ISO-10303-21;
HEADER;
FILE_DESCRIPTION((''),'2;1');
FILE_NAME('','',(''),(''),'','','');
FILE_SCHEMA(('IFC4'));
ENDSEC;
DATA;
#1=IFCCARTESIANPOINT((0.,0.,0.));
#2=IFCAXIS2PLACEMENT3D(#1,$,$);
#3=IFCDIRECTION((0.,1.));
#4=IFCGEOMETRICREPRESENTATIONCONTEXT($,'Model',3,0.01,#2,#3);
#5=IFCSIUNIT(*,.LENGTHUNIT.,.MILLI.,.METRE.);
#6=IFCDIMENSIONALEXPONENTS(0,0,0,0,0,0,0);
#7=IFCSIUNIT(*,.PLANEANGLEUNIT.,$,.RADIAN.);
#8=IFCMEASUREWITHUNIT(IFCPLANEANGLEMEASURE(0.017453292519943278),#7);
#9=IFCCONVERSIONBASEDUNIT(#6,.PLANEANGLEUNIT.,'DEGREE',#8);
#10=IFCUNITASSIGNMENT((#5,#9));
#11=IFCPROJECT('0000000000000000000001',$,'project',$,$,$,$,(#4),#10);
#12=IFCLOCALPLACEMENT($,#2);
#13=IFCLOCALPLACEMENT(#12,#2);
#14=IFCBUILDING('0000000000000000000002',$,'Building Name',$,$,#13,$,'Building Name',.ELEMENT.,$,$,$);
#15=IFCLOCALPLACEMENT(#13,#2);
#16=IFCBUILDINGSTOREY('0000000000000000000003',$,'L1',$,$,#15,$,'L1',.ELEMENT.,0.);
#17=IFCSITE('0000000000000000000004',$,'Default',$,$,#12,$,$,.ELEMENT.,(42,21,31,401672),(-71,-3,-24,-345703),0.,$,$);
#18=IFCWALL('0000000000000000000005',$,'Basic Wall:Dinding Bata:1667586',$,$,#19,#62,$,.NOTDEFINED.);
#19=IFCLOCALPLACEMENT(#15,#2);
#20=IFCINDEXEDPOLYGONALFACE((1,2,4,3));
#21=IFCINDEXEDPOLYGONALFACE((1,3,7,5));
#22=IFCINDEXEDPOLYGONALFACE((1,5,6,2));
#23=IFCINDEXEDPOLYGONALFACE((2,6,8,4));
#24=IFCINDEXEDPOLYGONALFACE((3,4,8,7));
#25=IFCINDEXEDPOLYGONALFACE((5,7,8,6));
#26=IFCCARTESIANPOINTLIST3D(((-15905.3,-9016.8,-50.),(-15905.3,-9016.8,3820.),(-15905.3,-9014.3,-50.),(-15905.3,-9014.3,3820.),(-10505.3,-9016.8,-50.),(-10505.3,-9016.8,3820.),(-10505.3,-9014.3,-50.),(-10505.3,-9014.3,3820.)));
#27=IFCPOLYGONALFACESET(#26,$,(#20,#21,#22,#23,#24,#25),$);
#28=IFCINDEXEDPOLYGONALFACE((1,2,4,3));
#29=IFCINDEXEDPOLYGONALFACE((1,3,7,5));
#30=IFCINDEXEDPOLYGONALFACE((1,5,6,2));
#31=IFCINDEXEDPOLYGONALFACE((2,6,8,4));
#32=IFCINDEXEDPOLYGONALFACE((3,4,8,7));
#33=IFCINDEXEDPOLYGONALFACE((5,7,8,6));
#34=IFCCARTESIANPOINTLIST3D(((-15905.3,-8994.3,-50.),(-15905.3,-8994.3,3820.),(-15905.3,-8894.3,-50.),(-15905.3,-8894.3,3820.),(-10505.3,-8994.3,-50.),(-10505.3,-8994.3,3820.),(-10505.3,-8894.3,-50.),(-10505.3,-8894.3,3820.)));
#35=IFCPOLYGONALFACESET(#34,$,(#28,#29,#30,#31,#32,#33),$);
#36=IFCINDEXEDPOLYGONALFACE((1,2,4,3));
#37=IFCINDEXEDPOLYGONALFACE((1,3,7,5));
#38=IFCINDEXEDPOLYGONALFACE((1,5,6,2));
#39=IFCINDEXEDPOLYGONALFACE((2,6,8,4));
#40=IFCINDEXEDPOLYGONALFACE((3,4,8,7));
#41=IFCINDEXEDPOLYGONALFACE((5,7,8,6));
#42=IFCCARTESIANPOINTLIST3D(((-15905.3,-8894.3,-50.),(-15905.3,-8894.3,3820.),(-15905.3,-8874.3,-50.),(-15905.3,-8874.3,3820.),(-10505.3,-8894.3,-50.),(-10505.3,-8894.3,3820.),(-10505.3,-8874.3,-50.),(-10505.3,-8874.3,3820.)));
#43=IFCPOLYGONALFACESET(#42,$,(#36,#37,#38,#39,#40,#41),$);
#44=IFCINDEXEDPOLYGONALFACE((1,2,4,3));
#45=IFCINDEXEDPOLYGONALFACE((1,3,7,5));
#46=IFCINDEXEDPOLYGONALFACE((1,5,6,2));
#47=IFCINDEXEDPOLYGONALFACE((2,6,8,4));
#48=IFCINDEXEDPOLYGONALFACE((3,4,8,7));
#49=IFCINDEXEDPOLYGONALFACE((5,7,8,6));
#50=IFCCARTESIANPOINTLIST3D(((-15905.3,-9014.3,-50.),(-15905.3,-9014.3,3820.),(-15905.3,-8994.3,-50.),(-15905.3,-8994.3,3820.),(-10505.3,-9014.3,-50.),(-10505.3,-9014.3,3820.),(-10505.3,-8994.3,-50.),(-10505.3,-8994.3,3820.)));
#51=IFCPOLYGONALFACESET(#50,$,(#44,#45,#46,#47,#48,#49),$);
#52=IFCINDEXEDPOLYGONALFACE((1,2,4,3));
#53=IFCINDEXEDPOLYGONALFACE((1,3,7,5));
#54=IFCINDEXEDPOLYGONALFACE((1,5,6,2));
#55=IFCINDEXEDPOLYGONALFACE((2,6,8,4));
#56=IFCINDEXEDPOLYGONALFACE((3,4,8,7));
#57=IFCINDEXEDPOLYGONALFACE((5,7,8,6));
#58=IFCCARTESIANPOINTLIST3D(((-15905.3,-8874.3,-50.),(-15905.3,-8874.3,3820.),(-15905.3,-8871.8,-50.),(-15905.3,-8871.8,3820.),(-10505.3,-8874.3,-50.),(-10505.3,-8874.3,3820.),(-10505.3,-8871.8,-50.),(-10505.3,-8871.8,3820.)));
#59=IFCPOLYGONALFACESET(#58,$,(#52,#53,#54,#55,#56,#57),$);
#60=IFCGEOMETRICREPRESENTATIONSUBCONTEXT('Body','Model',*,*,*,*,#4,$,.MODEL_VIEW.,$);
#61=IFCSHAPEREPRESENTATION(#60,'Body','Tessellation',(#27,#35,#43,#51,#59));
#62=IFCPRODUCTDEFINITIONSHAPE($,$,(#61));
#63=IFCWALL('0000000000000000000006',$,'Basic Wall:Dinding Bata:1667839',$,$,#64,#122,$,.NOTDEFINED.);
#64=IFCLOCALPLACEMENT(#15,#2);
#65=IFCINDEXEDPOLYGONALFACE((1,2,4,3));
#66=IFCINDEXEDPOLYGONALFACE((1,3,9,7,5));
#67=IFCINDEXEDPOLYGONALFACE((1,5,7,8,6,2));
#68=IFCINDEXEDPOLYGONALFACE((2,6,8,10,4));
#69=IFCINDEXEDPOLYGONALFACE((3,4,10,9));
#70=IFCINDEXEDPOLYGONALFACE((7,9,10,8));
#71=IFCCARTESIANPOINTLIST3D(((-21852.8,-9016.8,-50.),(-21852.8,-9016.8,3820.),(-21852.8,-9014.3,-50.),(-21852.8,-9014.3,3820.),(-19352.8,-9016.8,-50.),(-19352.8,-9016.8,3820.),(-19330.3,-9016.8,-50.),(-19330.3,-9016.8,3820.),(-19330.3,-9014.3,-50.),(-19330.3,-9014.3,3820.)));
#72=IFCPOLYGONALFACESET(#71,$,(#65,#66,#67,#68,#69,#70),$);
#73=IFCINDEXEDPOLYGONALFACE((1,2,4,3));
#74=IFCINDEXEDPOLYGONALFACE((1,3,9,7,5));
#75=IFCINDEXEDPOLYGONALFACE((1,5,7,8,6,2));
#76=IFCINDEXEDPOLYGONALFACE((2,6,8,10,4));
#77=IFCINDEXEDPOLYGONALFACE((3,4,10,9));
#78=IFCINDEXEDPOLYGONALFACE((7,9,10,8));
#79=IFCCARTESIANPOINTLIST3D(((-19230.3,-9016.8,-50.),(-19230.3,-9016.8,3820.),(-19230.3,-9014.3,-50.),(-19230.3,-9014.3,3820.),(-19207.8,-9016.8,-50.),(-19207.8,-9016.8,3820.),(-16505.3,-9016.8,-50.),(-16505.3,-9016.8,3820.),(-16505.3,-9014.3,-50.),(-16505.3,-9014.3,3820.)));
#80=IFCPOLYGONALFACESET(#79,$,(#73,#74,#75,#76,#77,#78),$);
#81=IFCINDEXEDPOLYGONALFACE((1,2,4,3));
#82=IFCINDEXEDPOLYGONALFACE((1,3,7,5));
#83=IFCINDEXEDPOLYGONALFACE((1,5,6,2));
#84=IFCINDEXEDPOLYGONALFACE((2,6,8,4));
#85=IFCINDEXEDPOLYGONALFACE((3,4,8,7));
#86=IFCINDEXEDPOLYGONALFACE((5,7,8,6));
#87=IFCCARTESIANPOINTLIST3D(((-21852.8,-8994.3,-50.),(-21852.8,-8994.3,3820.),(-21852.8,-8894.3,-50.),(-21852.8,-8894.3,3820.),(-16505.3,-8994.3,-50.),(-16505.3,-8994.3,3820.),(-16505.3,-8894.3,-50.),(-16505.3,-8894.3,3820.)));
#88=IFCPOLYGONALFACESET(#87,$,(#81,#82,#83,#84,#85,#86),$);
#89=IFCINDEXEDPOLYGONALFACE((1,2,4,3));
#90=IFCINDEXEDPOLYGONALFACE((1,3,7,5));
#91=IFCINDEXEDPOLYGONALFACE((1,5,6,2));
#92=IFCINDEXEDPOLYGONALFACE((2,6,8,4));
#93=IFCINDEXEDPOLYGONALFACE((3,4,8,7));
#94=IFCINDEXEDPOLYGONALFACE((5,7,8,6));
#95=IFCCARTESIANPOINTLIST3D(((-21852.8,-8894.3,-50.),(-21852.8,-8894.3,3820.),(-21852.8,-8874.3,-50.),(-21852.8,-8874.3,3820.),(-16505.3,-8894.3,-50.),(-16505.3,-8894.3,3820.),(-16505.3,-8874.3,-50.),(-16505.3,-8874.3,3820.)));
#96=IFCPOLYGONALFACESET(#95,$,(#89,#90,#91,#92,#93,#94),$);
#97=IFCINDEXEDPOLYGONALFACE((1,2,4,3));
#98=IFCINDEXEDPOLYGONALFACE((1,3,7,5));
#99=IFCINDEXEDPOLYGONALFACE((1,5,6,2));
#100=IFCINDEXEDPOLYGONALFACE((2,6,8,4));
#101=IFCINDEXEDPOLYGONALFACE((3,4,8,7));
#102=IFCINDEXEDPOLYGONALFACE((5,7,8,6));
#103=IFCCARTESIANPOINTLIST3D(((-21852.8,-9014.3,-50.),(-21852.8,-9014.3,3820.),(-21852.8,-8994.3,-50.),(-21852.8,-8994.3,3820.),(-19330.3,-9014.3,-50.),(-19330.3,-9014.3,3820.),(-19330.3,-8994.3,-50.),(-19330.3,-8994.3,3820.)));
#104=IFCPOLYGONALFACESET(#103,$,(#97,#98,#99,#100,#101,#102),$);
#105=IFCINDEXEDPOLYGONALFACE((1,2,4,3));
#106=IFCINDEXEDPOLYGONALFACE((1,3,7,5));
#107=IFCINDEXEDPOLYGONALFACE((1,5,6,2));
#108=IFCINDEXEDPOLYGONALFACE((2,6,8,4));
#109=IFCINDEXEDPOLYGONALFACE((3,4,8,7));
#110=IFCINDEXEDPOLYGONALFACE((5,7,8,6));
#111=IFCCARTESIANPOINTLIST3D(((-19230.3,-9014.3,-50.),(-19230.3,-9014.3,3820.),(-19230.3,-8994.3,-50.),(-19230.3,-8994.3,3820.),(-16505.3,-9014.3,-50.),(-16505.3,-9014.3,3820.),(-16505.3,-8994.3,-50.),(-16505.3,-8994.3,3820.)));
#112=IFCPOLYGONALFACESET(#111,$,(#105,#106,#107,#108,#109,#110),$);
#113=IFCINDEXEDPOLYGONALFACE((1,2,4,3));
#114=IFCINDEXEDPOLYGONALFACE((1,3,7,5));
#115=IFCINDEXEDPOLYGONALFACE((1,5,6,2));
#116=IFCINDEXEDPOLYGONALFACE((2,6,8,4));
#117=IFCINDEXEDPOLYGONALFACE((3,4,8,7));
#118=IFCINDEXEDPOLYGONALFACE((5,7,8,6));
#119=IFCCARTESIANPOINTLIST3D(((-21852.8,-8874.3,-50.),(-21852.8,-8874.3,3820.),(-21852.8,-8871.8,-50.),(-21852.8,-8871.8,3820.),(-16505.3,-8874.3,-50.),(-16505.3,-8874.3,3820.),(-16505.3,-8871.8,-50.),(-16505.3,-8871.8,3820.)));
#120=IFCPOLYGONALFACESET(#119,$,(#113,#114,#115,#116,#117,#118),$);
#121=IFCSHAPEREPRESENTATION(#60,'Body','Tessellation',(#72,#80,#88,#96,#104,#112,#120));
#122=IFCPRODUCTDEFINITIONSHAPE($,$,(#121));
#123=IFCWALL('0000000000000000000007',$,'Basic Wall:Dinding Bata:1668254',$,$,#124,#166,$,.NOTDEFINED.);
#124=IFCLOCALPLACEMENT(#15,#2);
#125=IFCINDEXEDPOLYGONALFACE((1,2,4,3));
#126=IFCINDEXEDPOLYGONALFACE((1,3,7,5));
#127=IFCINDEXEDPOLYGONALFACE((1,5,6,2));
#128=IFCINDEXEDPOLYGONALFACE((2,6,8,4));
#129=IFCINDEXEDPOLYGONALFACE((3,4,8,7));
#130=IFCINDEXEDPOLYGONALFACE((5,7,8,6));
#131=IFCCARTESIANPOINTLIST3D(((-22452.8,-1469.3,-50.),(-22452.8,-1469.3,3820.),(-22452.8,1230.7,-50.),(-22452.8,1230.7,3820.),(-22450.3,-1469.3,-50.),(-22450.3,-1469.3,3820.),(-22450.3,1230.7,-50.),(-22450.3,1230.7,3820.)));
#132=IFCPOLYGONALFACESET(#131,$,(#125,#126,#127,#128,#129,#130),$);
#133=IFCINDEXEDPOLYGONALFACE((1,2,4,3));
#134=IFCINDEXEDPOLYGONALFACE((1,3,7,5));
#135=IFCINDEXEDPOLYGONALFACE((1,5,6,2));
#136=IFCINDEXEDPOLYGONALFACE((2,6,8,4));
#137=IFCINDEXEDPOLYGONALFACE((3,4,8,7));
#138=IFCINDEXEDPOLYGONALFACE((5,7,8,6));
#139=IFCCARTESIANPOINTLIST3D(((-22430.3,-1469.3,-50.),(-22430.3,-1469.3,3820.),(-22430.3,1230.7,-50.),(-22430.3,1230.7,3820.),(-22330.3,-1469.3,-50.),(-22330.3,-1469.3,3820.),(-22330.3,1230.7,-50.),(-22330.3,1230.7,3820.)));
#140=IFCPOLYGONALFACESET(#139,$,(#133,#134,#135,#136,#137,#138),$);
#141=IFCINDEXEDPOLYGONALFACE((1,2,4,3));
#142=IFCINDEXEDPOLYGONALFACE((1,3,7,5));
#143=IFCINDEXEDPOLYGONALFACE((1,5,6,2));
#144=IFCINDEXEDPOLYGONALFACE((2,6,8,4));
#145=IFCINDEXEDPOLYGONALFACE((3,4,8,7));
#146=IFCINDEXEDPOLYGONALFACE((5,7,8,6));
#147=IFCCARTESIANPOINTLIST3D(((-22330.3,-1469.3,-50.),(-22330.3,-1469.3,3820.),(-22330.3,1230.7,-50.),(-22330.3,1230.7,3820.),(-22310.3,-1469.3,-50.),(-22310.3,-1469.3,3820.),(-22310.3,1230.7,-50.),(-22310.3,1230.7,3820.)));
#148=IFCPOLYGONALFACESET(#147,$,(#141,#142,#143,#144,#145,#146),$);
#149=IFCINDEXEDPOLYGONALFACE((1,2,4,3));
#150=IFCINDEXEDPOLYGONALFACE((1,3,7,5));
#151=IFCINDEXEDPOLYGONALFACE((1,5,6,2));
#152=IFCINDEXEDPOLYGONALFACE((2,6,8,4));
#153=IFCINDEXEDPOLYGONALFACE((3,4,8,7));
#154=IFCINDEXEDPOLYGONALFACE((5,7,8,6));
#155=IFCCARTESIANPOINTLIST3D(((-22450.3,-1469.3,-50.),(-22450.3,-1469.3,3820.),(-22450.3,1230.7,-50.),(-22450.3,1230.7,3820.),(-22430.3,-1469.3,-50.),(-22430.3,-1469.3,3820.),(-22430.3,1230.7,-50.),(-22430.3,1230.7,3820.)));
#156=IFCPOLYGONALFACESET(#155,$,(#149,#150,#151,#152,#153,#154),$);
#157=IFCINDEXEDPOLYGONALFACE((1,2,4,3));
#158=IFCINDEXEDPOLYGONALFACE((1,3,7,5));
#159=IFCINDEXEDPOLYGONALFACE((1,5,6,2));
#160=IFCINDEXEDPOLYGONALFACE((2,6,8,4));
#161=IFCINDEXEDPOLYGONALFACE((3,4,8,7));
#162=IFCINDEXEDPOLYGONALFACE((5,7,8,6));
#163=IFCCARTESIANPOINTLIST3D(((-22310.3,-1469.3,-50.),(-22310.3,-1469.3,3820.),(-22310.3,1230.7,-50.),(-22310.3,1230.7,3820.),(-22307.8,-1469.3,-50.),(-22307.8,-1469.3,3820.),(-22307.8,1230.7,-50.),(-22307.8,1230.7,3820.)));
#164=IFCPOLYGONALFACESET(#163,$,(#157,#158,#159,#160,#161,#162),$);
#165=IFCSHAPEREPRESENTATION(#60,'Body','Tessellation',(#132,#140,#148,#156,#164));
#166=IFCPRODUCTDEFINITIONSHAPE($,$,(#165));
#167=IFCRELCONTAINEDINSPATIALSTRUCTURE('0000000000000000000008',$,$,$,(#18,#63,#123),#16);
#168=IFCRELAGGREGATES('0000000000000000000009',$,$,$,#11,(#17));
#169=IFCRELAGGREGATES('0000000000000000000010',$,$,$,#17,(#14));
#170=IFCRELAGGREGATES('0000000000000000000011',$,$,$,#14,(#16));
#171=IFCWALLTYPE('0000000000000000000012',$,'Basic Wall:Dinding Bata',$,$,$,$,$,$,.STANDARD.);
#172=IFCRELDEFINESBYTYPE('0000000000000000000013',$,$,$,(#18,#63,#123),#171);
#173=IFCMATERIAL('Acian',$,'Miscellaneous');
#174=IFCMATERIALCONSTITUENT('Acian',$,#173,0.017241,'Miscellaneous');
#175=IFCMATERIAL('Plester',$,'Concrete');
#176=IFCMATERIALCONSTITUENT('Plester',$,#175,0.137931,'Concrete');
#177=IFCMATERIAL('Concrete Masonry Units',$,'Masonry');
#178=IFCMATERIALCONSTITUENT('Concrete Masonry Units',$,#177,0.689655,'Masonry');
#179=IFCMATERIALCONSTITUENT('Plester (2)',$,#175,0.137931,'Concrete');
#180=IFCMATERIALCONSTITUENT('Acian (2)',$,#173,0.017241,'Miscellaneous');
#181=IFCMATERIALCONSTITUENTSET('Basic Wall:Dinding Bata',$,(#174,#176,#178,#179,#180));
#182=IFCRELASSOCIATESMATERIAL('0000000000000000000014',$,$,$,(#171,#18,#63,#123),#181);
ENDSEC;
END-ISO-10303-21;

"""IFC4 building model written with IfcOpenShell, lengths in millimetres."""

from ifc_helpers import new_model, entity, si_unit, converted_unit, direction, frame, origin, place, context, subcontext, project, spatial, indexed_curve, outline, extrude, material, constituent, constituent_set, type_object, element, save


model = new_model("IFC4")

# Units and contexts
model_context = context("Model", 3, precision=0.01, world=origin(), true_north=direction((0.0, 1.0)))
body_context = subcontext(model_context, "Body", "Model", "MODEL_VIEW")
ifc_project = project(units=[si_unit("LENGTHUNIT", "METRE", prefix="MILLI"), converted_unit("PLANEANGLEUNIT", "DEGREE", entity("IfcPlaneAngleMeasure", 0.017453292519943278), si_unit("PLANEANGLEUNIT", "RADIAN"), dimensions=[0, 0, 0, 0, 0, 0, 0])], contexts=[model_context])

# Site, building, storey
site_placement = place(None, origin())
site = spatial("IfcSite", under=ifc_project, at=site_placement, Name="Default", CompositionType="ELEMENT", RefLatitude=(42, 21, 31, 401672), RefLongitude=(-71, -3, -24, -345703), RefElevation=0.0)
building_placement = place(site_placement, origin())
building = spatial("IfcBuilding", under=site, at=building_placement, Name="Building Name", LongName="Building Name", CompositionType="ELEMENT")
storey_placement = place(building_placement, origin())
storey = spatial("IfcBuildingStorey", under=building, at=storey_placement, Name="L1", LongName="L1", CompositionType="ELEMENT", Elevation=0.0)

# Walls
ifc_material_1 = material(Name="Acian", Category="Miscellaneous")
ifc_constituent_1 = constituent(ifc_material_1, Name="Acian", Category="Miscellaneous", fraction=0.017241)
ifc_material_2 = material(Name="Plester", Category="Concrete")
ifc_constituent_2 = constituent(ifc_material_2, Name="Plester", Category="Concrete", fraction=0.137931)
ifc_material_3 = material(Name="Concrete Masonry Units", Category="Masonry")
ifc_constituent_3 = constituent(ifc_material_3, Name="Concrete Masonry Units", Category="Masonry", fraction=0.689655)
ifc_constituent_4 = constituent(ifc_material_2, Name="Plester (2)", Category="Concrete", fraction=0.137931)
ifc_constituent_5 = constituent(ifc_material_1, Name="Acian (2)", Category="Miscellaneous", fraction=0.017241)
ifc_constituent_set = constituent_set(constituents=[ifc_constituent_1, ifc_constituent_2, ifc_constituent_3, ifc_constituent_4, ifc_constituent_5], Name="Basic Wall:Dinding Bata")
wall_type = type_object("IfcWallType", Name="Basic Wall:Dinding Bata", PredefinedType="STANDARD", material=ifc_constituent_set)
wall_1_placement = place(storey_placement, frame((-10505.3, -8944.3, -50.0), z_axis=(0.0, 0.0, 1.0), x_axis=(-1.0, 0.0, 0.0)))
element("IfcWall", 1, at=wall_1_placement, inside=storey, type_object=wall_type, material=ifc_constituent_set, Name="Basic Wall:Dinding Bata:1667586", PredefinedType="NOTDEFINED", context=body_context, shape_type="SweptSolid", body=[
    extrude(outline(indexed_curve([(-1.3, -2700.0), (1.2, -2700.0), (1.3, 2700.0), (-1.2, 2700.0), (-1.3, -2700.0)], self_intersect=False)), frame((2700.0, 71.3, 0.0), z_axis=(0.0, 0.0, 1.0), x_axis=(0.0, -1.0, 0.0)), (0.0, 0.0, 1.0), 3870.0),
    extrude(outline(indexed_curve([(-2700.0, -50.0), (2700.0, -50.0), (2700.0, 50.0), (-2700.0, 50.0), (-2700.0, -50.0)], self_intersect=False)), frame((2700.0, 0.0, 0.0)), (0.0, 0.0, 1.0), 3870.0),
    extrude(outline(indexed_curve([(-2700.0, -10.0), (2700.0, -10.0), (2700.0, 10.0), (-2700.0, 10.0), (-2700.0, -10.0)], self_intersect=False)), frame((2700.0, -60.0, 0.0)), (0.0, 0.0, 1.0), 3870.0),
    extrude(outline(indexed_curve([(-2700.0, -10.0), (2700.0, -10.0), (2700.0, 10.0), (-2700.0, 10.0), (-2700.0, -10.0)], self_intersect=False)), frame((2700.0, 60.0, 0.0)), (0.0, 0.0, 1.0), 3870.0),
    extrude(outline(indexed_curve([(-1.3, -2700.0), (1.2, -2700.0), (1.3, 2700.0), (-1.2, 2700.0), (-1.3, -2700.0)], self_intersect=False)), frame((2700.0, -71.3, 0.0), z_axis=(0.0, 0.0, 1.0), x_axis=(0.0, 1.0, 0.0)), (0.0, 0.0, 1.0), 3870.0),
])
wall_2_placement = place(storey_placement, frame((-16505.3, -8944.3, -50.0), z_axis=(0.0, 0.0, 1.0), x_axis=(-1.0, 0.0, 0.0)))
element("IfcWall", 2, at=wall_2_placement, inside=storey, type_object=wall_type, material=ifc_constituent_set, Name="Basic Wall:Dinding Bata:1667839", PredefinedType="NOTDEFINED", context=body_context, shape_type="SweptSolid", body=[
    extrude(outline(indexed_curve([(991.0, -1.0), (1013.5, -1.0), (1013.5, 1.5), (-1509.0, 1.5), (-1509.0, -1.0), (991.0, -1.0)], self_intersect=False)), frame((3838.5, 71.5, 0.0), z_axis=(0.0, 0.0, 1.0), x_axis=(-1.0, 0.0, 0.0)), (0.0, 0.0, 1.0), 3870.0),
    extrude(outline(indexed_curve([(-1630.5, -1.5), (1094.5, -1.5), (1094.5, 1.0), (1072.0, 1.0), (-1630.5, 1.0), (-1630.5, -1.5)], self_intersect=False)), frame((1630.5, 71.5, 0.0)), (0.0, 0.0, 1.0), 3870.0),
    extrude(outline(indexed_curve([(-2673.7, -50.0), (2673.7, -50.0), (2673.7, 50.0), (-2673.7, 50.0), (-2673.7, -50.0)], self_intersect=False)), frame((2673.7, 0.0, 0.0)), (0.0, 0.0, 1.0), 3870.0),
    extrude(outline(indexed_curve([(-2673.7, -10.0), (2673.7, -10.0), (2673.7, 10.0), (-2673.7, 10.0), (-2673.7, -10.0)], self_intersect=False)), frame((2673.7, -60.0, 0.0)), (0.0, 0.0, 1.0), 3870.0),
    extrude(outline(indexed_curve([(-1261.2, -10.0), (1261.2, -10.0), (1261.2, 10.0), (-1261.2, 10.0), (-1261.2, -10.0)], self_intersect=False)), frame((4086.2, 60.0, 0.0), z_axis=(0.0, 0.0, 1.0), x_axis=(-1.0, 0.0, 0.0)), (0.0, 0.0, 1.0), 3870.0),
    extrude(outline(indexed_curve([(-1362.5, -10.0), (1362.5, -10.0), (1362.5, 10.0), (-1362.5, 10.0), (-1362.5, -10.0)], self_intersect=False)), frame((1362.5, 60.0, 0.0)), (0.0, 0.0, 1.0), 3870.0),
    extrude(outline(indexed_curve([(-1.3, -2673.7), (1.2, -2673.7), (1.3, 2673.7), (-1.2, 2673.7), (-1.3, -2673.7)], self_intersect=False)), frame((2673.7, -71.3, 0.0), z_axis=(0.0, 0.0, 1.0), x_axis=(0.0, 1.0, 0.0)), (0.0, 0.0, 1.0), 3870.0),
])
wall_3_placement = place(storey_placement, frame((-22380.3, -1469.3, -50.0), z_axis=(0.0, 0.0, 1.0), x_axis=(0.0, 1.0, 0.0)))
element("IfcWall", 3, at=wall_3_placement, inside=storey, type_object=wall_type, material=ifc_constituent_set, Name="Basic Wall:Dinding Bata:1668254", PredefinedType="NOTDEFINED", context=body_context, shape_type="SweptSolid", body=[
    extrude(outline(indexed_curve([(-1.3, -1350.0), (1.2, -1350.0), (1.2, 1350.0), (-1.2, 1350.0), (-1.3, -1350.0)], self_intersect=False)), frame((1350.0, 71.3, 0.0), z_axis=(0.0, 0.0, 1.0), x_axis=(0.0, -1.0, 0.0)), (0.0, 0.0, 1.0), 3870.0),
    extrude(outline(indexed_curve([(-1350.0, -50.0), (1350.0, -50.0), (1350.0, 50.0), (-1350.0, 50.0), (-1350.0, -50.0)], self_intersect=False)), frame((1350.0, 0.0, 0.0)), (0.0, 0.0, 1.0), 3870.0),
    extrude(outline(indexed_curve([(-1350.0, -10.0), (1350.0, -10.0), (1350.0, 10.0), (-1350.0, 10.0), (-1350.0, -10.0)], self_intersect=False)), frame((1350.0, -60.0, 0.0)), (0.0, 0.0, 1.0), 3870.0),
    extrude(outline(indexed_curve([(-1350.0, -10.0), (1350.0, -10.0), (1350.0, 10.0), (-1350.0, 10.0), (-1350.0, -10.0)], self_intersect=False)), frame((1350.0, 60.0, 0.0)), (0.0, 0.0, 1.0), 3870.0),
    extrude(outline(indexed_curve([(-1.2, -1350.0), (1.2, -1350.0), (1.3, 1350.0), (-1.2, 1350.0), (-1.2, -1350.0)], self_intersect=False)), frame((1350.0, -71.3, 0.0), z_axis=(0.0, 0.0, 1.0), x_axis=(0.0, 1.0, 0.0)), (0.0, 0.0, 1.0), 3870.0),
])

save(model, "model.ifc")
